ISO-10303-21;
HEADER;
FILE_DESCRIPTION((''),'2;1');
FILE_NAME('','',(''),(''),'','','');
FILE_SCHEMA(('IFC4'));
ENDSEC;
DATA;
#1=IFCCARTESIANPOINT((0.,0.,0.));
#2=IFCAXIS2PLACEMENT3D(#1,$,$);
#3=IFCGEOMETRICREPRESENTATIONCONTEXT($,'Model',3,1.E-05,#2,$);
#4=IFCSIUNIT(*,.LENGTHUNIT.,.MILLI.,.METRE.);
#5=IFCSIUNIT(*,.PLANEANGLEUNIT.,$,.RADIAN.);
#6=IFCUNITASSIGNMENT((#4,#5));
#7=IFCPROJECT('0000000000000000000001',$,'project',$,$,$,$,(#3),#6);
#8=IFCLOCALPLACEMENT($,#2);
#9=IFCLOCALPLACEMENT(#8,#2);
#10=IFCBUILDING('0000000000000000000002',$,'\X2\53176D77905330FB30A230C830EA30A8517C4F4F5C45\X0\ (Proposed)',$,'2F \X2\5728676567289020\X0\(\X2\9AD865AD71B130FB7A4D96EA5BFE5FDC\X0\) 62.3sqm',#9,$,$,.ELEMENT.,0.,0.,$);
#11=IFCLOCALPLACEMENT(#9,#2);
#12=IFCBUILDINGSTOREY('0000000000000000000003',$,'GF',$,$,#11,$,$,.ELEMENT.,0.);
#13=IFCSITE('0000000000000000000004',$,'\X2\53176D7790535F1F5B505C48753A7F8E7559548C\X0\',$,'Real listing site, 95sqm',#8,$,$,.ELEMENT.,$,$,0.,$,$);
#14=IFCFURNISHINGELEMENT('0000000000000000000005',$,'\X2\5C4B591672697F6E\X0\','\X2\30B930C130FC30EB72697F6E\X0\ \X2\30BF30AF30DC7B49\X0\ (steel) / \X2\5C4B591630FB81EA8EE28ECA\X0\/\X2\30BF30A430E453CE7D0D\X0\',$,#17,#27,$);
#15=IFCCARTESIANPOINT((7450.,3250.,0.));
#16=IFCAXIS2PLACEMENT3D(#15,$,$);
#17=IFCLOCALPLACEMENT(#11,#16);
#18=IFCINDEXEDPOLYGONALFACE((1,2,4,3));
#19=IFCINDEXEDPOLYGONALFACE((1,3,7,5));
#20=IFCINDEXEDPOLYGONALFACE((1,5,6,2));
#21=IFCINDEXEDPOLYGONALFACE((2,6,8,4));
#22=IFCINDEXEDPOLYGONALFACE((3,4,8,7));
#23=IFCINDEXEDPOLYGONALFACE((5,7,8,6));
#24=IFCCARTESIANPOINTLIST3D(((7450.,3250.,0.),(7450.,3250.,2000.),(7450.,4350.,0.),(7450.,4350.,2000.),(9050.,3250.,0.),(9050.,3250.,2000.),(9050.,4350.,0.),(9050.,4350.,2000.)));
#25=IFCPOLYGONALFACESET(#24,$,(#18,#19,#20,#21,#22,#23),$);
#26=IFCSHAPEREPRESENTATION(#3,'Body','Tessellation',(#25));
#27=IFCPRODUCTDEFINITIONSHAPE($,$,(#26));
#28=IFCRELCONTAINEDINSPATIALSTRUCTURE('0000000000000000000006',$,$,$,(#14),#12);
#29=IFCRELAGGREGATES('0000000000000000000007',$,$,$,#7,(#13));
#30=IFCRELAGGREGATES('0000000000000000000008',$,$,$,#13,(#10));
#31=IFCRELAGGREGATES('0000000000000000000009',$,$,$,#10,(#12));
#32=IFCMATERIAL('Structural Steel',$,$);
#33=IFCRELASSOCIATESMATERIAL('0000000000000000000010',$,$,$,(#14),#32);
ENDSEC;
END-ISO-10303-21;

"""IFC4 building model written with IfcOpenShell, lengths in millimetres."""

from ifc_helpers import new_model, si_unit, frame, frame_2d, origin, place, context, project, spatial, rectangle, extrude, material, element, save


model = new_model("IFC4")

# Units and contexts
model_context = context("Model", 3, precision=1e-05, world=origin())
ifc_project = project(units=[si_unit("LENGTHUNIT", "METRE", prefix="MILLI"), si_unit("PLANEANGLEUNIT", "RADIAN")], contexts=[model_context])

# Site, building, storey
site_placement = place(None, origin())
site = spatial("IfcSite", under=ifc_project, at=site_placement, Name="北海道弟子屈町美留和", ObjectType="Real listing site, 95sqm", CompositionType="ELEMENT", RefElevation=0.0)
building_placement = place(site_placement, origin())
building = spatial("IfcBuilding", under=site, at=building_placement, Name="北海道・アトリエ兼住居 (Proposed)", ObjectType="2F 在来木造(高断熱・積雪対応) 62.3sqm", CompositionType="ELEMENT", ElevationOfRefHeight=0.0, ElevationOfTerrain=0.0)
storey_placement = place(building_placement, origin())
storey = spatial("IfcBuildingStorey", under=building, at=storey_placement, Name="GF", CompositionType="ELEMENT", Elevation=0.0)

# Shared definitions
ifc_material_1 = material(Name="Structural Steel")

# Furnishing element
furnishing_1_placement = place(storey_placement, frame((7450.0, 3250.0, 0.0)))
element("IfcFurnishingElement", 1, at=furnishing_1_placement, inside=storey, material=ifc_material_1, Name="屋外物置", Description="スチール物置 タクボ等 (steel) / 屋外・自転車/タイヤ収納", context=model_context, shape_type="SweptSolid", body=[
    extrude(rectangle(XDim=1600.0, YDim=1100.0, at=frame_2d((800.0, 550.0))), frame((7450.0, 3250.0, 0.0)), (0.0, 0.0, 1.0), 2000.0),
])

save(model, "model.ifc")
